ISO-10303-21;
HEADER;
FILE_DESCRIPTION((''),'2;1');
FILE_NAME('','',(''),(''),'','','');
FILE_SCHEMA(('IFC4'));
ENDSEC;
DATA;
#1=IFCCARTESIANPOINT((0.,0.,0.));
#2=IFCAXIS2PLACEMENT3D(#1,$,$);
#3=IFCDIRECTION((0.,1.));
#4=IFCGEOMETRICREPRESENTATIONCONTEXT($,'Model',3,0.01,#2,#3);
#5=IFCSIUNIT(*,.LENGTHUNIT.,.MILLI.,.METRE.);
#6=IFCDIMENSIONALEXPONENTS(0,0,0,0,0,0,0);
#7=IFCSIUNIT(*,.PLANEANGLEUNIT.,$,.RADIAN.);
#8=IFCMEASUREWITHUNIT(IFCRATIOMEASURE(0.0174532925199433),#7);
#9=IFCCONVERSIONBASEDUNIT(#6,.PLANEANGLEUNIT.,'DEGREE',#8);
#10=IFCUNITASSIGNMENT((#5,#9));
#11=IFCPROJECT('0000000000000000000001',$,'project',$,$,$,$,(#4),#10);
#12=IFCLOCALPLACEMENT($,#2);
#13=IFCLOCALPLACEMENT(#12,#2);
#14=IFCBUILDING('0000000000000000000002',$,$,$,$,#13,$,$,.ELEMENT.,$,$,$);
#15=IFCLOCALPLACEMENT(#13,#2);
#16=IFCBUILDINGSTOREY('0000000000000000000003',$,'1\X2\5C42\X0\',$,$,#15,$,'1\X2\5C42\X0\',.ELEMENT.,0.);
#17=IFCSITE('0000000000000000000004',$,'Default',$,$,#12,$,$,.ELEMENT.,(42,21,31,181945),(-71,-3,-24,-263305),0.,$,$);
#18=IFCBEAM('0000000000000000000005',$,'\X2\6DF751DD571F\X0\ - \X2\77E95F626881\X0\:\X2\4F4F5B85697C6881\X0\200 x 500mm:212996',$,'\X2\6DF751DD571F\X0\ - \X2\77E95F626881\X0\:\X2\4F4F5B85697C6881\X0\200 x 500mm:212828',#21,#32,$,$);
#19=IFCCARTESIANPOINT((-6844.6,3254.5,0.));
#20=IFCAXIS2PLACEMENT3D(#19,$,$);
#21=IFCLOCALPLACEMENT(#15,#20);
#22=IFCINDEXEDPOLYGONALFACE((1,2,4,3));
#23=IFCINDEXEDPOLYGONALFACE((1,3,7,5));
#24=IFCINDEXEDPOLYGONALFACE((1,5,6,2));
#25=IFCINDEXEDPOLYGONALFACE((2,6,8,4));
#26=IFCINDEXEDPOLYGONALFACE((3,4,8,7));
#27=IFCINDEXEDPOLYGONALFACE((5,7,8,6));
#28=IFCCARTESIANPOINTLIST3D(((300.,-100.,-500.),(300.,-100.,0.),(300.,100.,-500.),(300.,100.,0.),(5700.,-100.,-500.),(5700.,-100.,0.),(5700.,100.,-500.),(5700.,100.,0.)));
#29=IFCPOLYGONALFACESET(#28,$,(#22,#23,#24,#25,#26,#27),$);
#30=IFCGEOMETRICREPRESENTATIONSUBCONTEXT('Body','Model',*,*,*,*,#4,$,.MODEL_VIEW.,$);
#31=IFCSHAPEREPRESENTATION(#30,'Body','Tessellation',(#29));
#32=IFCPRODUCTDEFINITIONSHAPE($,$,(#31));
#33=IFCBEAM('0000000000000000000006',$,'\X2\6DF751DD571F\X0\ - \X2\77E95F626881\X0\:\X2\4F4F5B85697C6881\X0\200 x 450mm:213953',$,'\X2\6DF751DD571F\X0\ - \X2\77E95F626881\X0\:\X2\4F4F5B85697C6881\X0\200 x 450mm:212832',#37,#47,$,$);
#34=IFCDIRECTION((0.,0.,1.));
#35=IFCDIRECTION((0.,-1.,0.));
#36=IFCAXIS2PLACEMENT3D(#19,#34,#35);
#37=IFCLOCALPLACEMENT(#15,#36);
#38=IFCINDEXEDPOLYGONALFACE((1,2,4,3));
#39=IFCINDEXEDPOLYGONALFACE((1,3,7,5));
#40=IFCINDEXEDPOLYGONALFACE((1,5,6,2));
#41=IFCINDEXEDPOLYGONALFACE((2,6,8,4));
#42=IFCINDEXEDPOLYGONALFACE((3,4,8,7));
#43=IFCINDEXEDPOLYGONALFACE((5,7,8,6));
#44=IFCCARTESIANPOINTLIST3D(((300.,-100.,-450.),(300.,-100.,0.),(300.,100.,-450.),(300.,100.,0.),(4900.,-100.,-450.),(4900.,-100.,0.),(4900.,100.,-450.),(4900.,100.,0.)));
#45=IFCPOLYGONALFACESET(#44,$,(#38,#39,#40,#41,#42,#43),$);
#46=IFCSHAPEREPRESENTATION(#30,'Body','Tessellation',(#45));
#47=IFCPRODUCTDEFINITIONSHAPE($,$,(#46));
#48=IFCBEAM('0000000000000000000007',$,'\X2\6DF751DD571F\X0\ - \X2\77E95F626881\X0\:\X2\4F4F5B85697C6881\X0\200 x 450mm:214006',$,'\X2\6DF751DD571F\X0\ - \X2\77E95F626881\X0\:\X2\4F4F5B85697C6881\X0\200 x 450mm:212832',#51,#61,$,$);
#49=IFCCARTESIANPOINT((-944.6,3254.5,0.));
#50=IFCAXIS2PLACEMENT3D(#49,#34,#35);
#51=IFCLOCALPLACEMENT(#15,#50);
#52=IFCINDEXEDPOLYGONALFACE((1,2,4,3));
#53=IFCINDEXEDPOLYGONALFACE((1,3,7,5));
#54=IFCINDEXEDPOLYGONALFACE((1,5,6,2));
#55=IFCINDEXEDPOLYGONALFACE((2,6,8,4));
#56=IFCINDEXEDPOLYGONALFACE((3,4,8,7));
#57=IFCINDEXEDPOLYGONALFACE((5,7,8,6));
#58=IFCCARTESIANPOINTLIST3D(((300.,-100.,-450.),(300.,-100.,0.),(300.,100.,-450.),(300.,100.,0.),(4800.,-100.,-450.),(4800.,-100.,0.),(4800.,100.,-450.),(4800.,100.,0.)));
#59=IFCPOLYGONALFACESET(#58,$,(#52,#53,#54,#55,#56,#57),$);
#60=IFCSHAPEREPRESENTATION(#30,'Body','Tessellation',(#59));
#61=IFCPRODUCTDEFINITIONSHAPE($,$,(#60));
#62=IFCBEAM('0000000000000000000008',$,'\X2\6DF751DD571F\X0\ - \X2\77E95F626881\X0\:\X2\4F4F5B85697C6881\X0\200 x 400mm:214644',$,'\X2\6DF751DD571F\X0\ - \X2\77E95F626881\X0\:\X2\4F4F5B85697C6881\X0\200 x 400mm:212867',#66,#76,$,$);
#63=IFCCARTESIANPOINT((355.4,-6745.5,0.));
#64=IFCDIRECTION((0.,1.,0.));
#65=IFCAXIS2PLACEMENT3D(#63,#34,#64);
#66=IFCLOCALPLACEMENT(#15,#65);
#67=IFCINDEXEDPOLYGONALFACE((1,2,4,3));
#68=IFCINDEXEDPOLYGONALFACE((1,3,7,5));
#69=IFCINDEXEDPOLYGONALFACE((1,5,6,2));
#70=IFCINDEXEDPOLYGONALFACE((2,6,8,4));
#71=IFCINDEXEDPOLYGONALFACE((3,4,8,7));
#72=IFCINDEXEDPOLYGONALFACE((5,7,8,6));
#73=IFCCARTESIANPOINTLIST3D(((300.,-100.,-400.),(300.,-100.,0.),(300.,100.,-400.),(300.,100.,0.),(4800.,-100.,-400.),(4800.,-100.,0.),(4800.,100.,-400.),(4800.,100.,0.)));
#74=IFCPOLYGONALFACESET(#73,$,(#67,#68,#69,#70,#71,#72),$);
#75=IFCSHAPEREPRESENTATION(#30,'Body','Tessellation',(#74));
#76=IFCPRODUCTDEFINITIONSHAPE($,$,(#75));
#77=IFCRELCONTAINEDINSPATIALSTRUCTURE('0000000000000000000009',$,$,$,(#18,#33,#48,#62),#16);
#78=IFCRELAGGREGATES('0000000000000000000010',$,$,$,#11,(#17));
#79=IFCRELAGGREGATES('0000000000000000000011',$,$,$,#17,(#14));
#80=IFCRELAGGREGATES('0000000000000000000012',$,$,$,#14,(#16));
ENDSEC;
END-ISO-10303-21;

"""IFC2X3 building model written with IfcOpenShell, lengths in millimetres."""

from ifc_helpers import new_model, entity, si_unit, converted_unit, direction, frame, frame_2d, origin, place, context, subcontext, project, spatial, rectangle, extrude, element, save


model = new_model("IFC2X3")

# Units and contexts
model_context = context("Model", 3, precision=0.01, world=origin(), true_north=direction((0.0, 1.0)))
body_context = subcontext(model_context, "Body", "Model", "MODEL_VIEW")
ifc_project = project(units=[si_unit("LENGTHUNIT", "METRE", prefix="MILLI"), converted_unit("PLANEANGLEUNIT", "DEGREE", entity("IfcRatioMeasure", 0.0174532925199433), si_unit("PLANEANGLEUNIT", "RADIAN"), dimensions=[0, 0, 0, 0, 0, 0, 0])], contexts=[model_context])

# Site, building, storey
site_placement = place(None, origin())
site = spatial("IfcSite", under=ifc_project, at=site_placement, Name="Default", CompositionType="ELEMENT", RefLatitude=(42, 21, 31, 181945), RefLongitude=(-71, -3, -24, -263305), RefElevation=0.0)
building_placement = place(site_placement, origin())
building = spatial("IfcBuilding", under=site, at=building_placement, CompositionType="ELEMENT")
storey_placement = place(building_placement, origin())
storey = spatial("IfcBuildingStorey", under=building, at=storey_placement, Name="1层", LongName="1层", CompositionType="ELEMENT", Elevation=0.0)

# Beams
beam_1_placement = place(storey_placement, frame((-6844.6, 3254.5, 0.0)))
element("IfcBeam", 1, at=beam_1_placement, inside=storey, Name="混凝土 - 矩形梁:住宅楼梁200 x 500mm:212996", ObjectType="混凝土 - 矩形梁:住宅楼梁200 x 500mm:212828", context=body_context, shape_type="SweptSolid", body=[
    extrude(rectangle(XDim=500.0, YDim=200.0, at=frame_2d((0.0, 0.0), x_axis=(1.0, 0.0))), frame((300.0, 0.0, -250.0), z_axis=(1.0, 0.0, 0.0), x_axis=(0.0, 0.0, -1.0)), (0.0, 0.0, 1.0), 5400.0),
])
beam_2_placement = place(storey_placement, frame((-6844.6, 3254.5, 0.0), z_axis=(0.0, 0.0, 1.0), x_axis=(0.0, -1.0, 0.0)))
element("IfcBeam", 2, at=beam_2_placement, inside=storey, Name="混凝土 - 矩形梁:住宅楼梁200 x 450mm:213953", ObjectType="混凝土 - 矩形梁:住宅楼梁200 x 450mm:212832", context=body_context, shape_type="SweptSolid", body=[
    extrude(rectangle(XDim=450.0, YDim=200.0, at=frame_2d((0.0, 0.0), x_axis=(1.0, 0.0))), frame((300.0, 0.0, -225.0), z_axis=(1.0, 0.0, 0.0), x_axis=(0.0, 0.0, -1.0)), (0.0, 0.0, 1.0), 4600.0),
])
beam_3_placement = place(storey_placement, frame((-944.6, 3254.5, 0.0), z_axis=(0.0, 0.0, 1.0), x_axis=(0.0, -1.0, 0.0)))
element("IfcBeam", 3, at=beam_3_placement, inside=storey, Name="混凝土 - 矩形梁:住宅楼梁200 x 450mm:214006", ObjectType="混凝土 - 矩形梁:住宅楼梁200 x 450mm:212832", context=body_context, shape_type="SweptSolid", body=[
    extrude(rectangle(XDim=450.0, YDim=200.0, at=frame_2d((0.0, 0.0), x_axis=(1.0, 0.0))), frame((300.0, 0.0, -225.0), z_axis=(1.0, 0.0, 0.0), x_axis=(0.0, 0.0, -1.0)), (0.0, 0.0, 1.0), 4500.0),
])
beam_4_placement = place(storey_placement, frame((355.4, -6745.5, 0.0), z_axis=(0.0, 0.0, 1.0), x_axis=(0.0, 1.0, 0.0)))
element("IfcBeam", 4, at=beam_4_placement, inside=storey, Name="混凝土 - 矩形梁:住宅楼梁200 x 400mm:214644", ObjectType="混凝土 - 矩形梁:住宅楼梁200 x 400mm:212867", context=body_context, shape_type="SweptSolid", body=[
    extrude(rectangle(XDim=400.0, YDim=200.0, at=frame_2d((0.0, 0.0), x_axis=(1.0, 0.0))), frame((300.0, 0.0, -200.0), z_axis=(1.0, 0.0, 0.0), x_axis=(0.0, 0.0, -1.0)), (0.0, 0.0, 1.0), 4500.0),
])

save(model, "model.ifc")
